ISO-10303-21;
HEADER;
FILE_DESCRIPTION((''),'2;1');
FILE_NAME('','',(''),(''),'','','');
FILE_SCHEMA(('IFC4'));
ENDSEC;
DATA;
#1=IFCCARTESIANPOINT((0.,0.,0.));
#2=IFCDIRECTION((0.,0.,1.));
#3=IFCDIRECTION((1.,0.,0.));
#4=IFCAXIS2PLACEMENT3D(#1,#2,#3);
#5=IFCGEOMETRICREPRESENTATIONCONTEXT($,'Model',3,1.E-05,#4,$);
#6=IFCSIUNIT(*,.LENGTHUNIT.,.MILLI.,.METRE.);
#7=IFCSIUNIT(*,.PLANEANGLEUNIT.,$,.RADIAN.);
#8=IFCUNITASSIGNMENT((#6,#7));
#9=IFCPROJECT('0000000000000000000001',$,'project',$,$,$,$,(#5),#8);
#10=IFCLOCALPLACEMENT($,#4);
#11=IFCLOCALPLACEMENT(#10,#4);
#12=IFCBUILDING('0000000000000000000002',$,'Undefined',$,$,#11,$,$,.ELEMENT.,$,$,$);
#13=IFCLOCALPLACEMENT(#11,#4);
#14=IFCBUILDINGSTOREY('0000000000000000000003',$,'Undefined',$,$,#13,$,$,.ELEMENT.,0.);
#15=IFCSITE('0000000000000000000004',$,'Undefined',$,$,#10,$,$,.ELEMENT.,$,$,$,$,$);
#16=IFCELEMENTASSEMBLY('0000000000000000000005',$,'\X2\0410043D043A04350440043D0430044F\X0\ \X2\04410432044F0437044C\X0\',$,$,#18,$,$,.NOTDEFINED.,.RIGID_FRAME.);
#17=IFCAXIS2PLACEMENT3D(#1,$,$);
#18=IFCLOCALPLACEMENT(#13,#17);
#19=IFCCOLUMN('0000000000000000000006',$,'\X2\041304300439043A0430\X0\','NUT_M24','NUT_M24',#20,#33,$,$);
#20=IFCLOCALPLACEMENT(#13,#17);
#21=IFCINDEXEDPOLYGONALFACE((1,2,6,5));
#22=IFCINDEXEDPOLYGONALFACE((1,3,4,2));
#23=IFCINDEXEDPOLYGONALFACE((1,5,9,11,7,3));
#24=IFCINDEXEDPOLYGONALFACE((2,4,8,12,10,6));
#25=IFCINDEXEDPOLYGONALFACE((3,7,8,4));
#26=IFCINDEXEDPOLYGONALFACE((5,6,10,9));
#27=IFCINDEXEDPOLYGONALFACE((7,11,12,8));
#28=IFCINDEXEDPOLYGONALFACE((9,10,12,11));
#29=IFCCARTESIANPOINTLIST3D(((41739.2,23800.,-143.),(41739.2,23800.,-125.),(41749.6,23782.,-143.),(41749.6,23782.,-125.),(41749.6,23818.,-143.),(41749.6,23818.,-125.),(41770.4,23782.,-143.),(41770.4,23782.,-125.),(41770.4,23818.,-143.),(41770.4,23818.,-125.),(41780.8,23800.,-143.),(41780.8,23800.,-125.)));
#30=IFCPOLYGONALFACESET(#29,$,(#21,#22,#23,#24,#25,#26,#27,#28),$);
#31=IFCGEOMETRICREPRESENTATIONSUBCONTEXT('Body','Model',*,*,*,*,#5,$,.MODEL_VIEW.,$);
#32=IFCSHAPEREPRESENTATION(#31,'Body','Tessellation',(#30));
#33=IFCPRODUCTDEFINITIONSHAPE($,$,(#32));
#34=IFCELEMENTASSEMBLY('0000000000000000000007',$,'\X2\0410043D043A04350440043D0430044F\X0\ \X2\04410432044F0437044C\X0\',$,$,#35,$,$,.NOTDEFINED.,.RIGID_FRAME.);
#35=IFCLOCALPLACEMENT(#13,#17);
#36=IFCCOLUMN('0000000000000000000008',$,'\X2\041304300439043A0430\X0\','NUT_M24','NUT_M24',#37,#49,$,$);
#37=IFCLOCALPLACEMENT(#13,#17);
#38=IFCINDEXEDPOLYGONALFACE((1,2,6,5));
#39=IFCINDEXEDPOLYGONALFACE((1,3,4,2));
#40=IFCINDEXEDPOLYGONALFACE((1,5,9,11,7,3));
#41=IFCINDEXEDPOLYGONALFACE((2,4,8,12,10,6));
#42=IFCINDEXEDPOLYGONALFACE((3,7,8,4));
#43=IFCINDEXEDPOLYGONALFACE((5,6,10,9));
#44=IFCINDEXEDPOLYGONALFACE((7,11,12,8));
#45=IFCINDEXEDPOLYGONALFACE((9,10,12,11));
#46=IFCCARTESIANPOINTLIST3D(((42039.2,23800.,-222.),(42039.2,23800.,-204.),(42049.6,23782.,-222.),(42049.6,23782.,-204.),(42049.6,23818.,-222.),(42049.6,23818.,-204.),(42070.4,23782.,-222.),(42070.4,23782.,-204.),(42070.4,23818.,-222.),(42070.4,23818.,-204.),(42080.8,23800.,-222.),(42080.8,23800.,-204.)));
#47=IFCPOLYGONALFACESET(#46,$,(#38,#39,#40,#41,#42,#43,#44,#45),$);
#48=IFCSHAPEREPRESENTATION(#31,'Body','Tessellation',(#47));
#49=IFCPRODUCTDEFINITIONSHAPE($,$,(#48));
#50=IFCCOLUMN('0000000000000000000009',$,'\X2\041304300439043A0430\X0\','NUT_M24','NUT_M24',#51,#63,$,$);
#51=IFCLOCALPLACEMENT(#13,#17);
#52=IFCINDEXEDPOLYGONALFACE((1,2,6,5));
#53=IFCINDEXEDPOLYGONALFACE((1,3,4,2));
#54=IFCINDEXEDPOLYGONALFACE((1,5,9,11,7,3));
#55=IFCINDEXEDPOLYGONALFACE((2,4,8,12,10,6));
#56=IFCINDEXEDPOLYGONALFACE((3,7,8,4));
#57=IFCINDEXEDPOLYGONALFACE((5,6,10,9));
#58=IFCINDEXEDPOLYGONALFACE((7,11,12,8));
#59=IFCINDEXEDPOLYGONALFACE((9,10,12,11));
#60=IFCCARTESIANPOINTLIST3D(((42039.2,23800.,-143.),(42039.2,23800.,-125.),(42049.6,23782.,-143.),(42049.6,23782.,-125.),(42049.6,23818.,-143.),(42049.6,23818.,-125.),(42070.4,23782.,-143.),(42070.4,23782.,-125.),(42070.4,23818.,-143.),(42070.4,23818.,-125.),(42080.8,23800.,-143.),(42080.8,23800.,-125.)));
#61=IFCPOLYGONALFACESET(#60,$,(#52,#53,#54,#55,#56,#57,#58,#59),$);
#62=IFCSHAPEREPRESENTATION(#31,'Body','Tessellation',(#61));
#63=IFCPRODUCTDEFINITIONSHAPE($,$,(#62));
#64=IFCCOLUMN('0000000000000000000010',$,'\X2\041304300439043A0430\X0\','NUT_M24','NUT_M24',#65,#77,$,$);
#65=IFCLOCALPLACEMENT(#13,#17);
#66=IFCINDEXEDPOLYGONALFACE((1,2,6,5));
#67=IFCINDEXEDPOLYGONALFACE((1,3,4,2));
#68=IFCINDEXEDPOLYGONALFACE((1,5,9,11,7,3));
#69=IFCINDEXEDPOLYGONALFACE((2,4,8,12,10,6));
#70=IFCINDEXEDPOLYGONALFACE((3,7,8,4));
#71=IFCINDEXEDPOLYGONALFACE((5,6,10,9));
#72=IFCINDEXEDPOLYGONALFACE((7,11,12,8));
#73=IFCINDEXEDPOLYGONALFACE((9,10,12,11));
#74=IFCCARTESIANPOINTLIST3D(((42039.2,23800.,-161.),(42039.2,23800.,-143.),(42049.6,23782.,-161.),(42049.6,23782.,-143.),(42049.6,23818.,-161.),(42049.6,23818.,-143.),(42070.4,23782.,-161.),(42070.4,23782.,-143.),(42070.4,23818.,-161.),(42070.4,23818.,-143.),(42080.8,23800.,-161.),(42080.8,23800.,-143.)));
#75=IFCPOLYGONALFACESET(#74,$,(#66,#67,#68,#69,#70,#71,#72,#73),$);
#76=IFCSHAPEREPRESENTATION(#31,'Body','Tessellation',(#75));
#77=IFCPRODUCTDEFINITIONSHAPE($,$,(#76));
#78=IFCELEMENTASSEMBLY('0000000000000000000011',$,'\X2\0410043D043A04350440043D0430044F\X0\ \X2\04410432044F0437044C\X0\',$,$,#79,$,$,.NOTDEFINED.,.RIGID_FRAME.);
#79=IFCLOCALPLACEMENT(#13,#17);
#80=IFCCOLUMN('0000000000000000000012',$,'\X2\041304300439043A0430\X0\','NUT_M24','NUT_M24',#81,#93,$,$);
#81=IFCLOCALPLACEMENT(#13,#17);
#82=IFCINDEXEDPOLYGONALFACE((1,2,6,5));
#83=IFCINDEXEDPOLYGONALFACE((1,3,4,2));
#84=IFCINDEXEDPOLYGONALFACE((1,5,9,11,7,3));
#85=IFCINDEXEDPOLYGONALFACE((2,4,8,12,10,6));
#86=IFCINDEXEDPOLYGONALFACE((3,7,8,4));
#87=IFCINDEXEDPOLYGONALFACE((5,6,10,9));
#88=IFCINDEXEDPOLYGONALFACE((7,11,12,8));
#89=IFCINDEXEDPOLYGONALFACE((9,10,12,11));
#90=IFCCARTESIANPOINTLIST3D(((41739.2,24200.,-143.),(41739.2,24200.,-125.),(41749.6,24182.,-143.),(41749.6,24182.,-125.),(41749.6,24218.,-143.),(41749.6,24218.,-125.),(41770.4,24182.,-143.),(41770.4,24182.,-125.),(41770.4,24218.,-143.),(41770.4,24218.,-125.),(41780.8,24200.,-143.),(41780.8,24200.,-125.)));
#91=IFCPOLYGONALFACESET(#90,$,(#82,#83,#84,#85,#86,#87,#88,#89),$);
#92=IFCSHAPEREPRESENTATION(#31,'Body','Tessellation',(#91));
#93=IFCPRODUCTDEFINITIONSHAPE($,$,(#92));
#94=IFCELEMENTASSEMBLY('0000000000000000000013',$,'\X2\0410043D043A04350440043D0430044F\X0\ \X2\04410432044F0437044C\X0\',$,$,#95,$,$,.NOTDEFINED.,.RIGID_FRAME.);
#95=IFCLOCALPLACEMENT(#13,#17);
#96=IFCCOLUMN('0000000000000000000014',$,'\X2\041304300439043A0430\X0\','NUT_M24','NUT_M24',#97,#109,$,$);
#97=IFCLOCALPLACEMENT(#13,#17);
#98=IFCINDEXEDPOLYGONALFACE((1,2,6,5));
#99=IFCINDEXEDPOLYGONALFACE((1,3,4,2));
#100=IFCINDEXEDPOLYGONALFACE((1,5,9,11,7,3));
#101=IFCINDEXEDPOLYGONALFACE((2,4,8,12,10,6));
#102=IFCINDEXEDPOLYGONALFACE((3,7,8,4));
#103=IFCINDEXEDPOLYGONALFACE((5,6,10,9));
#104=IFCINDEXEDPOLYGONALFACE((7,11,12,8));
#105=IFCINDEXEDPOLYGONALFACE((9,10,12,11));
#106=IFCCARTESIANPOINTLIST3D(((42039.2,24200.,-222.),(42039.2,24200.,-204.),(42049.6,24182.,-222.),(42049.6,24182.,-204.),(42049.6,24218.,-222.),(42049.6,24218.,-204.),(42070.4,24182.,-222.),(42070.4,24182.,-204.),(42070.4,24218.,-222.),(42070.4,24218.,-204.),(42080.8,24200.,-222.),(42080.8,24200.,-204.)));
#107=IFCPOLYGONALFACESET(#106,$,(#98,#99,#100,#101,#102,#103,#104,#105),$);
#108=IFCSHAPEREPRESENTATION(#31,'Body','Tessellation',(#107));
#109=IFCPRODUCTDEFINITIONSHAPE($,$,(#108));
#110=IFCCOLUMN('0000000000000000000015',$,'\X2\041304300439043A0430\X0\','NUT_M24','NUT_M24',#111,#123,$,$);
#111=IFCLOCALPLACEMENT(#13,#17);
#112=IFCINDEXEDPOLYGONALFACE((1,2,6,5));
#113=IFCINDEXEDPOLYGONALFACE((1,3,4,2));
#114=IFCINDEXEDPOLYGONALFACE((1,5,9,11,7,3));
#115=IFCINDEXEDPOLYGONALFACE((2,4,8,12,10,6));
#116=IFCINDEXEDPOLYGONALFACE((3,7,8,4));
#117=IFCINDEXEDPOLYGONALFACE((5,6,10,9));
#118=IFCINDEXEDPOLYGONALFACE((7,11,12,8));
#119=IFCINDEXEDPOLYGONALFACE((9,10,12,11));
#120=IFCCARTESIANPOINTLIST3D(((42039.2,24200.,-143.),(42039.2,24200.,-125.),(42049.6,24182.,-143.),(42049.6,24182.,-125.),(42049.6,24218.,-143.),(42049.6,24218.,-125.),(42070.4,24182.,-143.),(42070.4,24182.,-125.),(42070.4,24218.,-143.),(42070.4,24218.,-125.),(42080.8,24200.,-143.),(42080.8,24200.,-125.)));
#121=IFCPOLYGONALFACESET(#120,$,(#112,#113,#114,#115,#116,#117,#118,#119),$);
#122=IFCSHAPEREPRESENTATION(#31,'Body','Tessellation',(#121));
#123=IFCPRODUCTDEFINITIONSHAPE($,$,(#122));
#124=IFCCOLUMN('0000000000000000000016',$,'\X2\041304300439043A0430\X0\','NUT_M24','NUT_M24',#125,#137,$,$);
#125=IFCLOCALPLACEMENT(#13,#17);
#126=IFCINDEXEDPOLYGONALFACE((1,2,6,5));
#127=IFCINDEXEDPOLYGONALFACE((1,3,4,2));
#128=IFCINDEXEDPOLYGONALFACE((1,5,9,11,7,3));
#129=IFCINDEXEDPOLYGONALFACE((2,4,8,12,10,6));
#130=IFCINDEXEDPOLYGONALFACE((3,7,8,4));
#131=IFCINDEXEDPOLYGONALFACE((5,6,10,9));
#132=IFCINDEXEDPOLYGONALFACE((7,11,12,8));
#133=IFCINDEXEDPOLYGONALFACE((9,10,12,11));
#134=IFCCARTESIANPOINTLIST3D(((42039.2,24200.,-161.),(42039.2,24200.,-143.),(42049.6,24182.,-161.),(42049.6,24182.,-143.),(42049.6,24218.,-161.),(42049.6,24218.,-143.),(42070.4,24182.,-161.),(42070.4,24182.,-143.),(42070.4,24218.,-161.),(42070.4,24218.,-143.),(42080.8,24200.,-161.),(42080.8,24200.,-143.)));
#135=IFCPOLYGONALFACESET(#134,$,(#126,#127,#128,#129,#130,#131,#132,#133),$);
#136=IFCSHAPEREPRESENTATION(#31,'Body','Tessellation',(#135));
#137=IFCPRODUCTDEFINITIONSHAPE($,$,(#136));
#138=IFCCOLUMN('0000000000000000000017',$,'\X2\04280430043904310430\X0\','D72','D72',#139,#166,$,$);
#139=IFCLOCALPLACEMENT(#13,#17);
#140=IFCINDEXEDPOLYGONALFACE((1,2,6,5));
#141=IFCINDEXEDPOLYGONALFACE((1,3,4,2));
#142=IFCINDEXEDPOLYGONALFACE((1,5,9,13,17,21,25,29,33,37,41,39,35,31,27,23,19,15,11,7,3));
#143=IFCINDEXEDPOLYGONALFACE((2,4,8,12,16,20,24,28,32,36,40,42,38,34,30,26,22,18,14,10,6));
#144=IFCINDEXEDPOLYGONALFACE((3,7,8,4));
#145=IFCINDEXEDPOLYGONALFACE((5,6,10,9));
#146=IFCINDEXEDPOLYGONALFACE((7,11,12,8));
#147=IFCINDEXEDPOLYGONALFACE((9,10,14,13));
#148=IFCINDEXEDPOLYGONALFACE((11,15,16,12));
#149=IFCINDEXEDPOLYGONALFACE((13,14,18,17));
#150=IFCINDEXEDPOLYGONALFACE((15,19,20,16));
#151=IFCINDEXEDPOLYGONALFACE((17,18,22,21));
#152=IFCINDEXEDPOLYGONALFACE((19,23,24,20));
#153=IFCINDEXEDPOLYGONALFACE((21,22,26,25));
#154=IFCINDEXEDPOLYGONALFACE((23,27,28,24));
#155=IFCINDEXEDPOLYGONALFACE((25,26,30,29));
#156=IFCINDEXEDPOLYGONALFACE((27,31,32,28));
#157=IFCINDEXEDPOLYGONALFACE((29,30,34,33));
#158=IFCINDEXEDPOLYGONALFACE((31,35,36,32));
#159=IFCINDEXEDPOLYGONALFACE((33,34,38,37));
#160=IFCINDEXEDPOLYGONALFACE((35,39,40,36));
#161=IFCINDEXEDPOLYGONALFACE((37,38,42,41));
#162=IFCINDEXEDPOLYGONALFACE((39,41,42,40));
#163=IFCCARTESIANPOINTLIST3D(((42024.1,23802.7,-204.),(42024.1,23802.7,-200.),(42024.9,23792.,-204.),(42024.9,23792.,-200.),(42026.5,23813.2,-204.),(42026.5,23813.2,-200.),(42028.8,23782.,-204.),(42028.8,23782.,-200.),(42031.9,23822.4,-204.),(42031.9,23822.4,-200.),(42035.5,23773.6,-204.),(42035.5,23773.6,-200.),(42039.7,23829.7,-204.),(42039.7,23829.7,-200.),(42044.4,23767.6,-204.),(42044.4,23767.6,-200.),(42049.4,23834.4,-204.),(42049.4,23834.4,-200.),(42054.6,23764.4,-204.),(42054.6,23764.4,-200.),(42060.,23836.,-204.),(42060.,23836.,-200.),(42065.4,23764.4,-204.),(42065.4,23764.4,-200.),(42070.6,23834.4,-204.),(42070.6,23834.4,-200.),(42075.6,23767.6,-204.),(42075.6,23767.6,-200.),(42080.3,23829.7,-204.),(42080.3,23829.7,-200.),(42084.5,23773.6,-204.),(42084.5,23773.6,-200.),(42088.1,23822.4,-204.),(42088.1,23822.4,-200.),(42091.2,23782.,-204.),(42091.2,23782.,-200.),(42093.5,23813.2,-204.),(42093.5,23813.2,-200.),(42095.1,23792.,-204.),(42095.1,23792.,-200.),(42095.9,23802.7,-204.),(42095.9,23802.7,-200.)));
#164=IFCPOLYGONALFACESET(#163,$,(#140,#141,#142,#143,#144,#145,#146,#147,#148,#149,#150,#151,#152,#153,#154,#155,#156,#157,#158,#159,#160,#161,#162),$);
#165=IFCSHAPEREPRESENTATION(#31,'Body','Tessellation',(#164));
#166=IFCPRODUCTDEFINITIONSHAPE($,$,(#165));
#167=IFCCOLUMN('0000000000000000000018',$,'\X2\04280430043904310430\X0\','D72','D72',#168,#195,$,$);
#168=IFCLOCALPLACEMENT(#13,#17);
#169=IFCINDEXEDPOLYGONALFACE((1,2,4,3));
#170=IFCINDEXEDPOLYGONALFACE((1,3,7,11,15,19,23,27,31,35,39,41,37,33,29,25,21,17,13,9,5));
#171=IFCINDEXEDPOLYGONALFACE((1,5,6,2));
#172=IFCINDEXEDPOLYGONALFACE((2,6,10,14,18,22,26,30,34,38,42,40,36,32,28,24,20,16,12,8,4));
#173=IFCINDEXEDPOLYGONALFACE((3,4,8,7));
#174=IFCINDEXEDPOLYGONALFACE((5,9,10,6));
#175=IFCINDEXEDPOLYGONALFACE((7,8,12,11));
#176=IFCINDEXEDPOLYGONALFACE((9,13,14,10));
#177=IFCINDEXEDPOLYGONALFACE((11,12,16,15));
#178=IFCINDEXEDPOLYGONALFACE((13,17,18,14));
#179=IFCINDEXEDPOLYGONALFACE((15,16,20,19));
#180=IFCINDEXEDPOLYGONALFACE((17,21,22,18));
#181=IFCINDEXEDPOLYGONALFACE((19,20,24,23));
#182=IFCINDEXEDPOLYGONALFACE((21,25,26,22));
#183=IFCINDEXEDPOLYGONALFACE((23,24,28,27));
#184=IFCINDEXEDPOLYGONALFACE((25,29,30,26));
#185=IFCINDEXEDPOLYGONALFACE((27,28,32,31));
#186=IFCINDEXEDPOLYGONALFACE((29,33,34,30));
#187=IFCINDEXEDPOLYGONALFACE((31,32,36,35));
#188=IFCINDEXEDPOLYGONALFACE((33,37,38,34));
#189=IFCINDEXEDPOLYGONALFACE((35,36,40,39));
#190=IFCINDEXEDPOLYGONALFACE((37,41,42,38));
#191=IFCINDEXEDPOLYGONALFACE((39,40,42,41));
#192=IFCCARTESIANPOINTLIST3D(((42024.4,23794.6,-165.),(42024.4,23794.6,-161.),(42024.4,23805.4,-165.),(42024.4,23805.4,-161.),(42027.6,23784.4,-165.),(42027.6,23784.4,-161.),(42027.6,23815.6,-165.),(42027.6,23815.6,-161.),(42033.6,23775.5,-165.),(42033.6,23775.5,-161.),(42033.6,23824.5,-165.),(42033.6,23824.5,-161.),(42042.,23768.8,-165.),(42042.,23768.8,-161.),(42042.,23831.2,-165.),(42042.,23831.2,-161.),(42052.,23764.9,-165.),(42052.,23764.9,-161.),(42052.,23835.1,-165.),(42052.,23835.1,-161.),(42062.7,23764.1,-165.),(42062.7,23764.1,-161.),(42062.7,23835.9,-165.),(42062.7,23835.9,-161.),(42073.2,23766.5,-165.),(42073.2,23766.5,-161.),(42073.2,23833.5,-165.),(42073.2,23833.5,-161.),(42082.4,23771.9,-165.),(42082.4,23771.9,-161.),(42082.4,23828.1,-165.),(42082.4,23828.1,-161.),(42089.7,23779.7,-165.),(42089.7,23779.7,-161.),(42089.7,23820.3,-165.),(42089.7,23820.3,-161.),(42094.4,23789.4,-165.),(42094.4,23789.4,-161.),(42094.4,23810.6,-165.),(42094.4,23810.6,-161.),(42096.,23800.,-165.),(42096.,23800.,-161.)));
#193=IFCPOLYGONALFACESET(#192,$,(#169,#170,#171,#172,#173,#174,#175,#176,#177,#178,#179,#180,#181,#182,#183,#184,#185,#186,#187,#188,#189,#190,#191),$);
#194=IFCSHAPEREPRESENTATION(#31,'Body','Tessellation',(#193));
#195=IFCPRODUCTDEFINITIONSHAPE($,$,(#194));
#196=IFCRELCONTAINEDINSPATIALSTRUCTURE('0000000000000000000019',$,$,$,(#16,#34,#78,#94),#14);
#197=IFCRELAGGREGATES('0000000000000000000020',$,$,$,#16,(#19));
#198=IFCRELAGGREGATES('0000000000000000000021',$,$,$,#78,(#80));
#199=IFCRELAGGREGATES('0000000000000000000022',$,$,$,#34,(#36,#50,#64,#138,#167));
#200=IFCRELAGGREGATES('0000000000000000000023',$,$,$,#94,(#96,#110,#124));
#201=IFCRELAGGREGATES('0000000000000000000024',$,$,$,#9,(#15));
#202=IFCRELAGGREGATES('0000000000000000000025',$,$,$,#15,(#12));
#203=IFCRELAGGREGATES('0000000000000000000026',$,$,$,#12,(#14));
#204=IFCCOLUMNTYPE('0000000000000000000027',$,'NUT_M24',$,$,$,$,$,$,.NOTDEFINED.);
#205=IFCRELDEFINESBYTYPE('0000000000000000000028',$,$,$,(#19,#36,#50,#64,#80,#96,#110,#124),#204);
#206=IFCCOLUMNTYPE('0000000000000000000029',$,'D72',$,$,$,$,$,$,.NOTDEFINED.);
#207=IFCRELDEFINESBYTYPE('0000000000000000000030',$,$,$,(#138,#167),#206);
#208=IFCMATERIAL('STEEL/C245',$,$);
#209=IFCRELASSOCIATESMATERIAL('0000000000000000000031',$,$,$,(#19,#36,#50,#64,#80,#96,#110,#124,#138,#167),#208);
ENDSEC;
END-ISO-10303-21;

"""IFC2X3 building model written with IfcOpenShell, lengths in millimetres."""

from ifc_helpers import new_model, si_unit, frame, origin_with_axes, origin_2d_with_axis, place, context, subcontext, project, spatial, polyline, circle, outline, extrude, material, type_object, element, aggregate, save


model = new_model("IFC2X3")

# Units and contexts
model_context = context("Model", 3, precision=1e-05, world=origin_with_axes())
body_context = subcontext(model_context, "Body", "Model", "MODEL_VIEW")
ifc_project = project(units=[si_unit("LENGTHUNIT", "METRE", prefix="MILLI"), si_unit("PLANEANGLEUNIT", "RADIAN")], contexts=[model_context])

# Site, building, storey
site_placement = place(None, origin_with_axes())
site = spatial("IfcSite", under=ifc_project, at=site_placement, Name="Undefined", CompositionType="ELEMENT")
building_placement = place(site_placement, origin_with_axes())
building = spatial("IfcBuilding", under=site, at=building_placement, Name="Undefined", CompositionType="ELEMENT")
storey_placement = place(building_placement, origin_with_axes())
storey = spatial("IfcBuildingStorey", under=building, at=storey_placement, Name="Undefined", CompositionType="ELEMENT", Elevation=0.0)

# Element assembly, column
ifc_material_1 = material(Name="STEEL/C245")
assembly_1_placement = place(storey_placement, origin_with_axes())
assembly_1 = element("IfcElementAssembly", 1, at=assembly_1_placement, inside=storey, Name="Анкерная связь", AssemblyPlace="NOTDEFINED", PredefinedType="RIGID_FRAME")
column_type_1 = type_object("IfcColumnType", Name="NUT_M24", PredefinedType="NOTDEFINED")
column_1_placement = place(assembly_1_placement, frame((41760.0, 23800.0, -125.0), z_axis=(0.0, 0.0, -1.0), x_axis=(0.0, -1.0, 0.0)))
column_1 = element("IfcColumn", 2, at=column_1_placement, type_object=column_type_1, material=ifc_material_1, Name="Гайка", Description="NUT_M24", ObjectType="NUT_M24", context=body_context, shape_type="SweptSolid", body=[
    extrude(outline(polyline([(-10.4, 18.0), (10.4, 18.0), (20.8, 0.0), (10.4, -18.0), (-10.4, -18.0), (-20.8, 0.0), (-10.4, 18.0)])), frame((0.0, 0.0, 18.0), z_axis=(0.0, 0.0, -1.0), x_axis=(0.0, 1.0, 0.0)), (0.0, 0.0, 1.0), 18.0),
])

# Element assembly, columns
assembly_2_placement = place(storey_placement, origin_with_axes())
assembly_2 = element("IfcElementAssembly", 3, at=assembly_2_placement, inside=storey, Name="Анкерная связь", AssemblyPlace="NOTDEFINED", PredefinedType="RIGID_FRAME")
column_2_placement = place(assembly_2_placement, frame((42060.0, 23800.0, -204.0), z_axis=(0.0, 0.0, -1.0), x_axis=(0.0, 1.0, 0.0)))
column_2 = element("IfcColumn", 4, at=column_2_placement, type_object=column_type_1, material=ifc_material_1, Name="Гайка", Description="NUT_M24", ObjectType="NUT_M24", context=body_context, shape_type="SweptSolid", body=[
    extrude(outline(polyline([(-10.4, 18.0), (10.4, 18.0), (20.8, 0.0), (10.4, -18.0), (-10.4, -18.0), (-20.8, 0.0), (-10.4, 18.0)])), frame((0.0, 0.0, 18.0), z_axis=(0.0, 0.0, -1.0), x_axis=(0.0, 1.0, 0.0)), (0.0, 0.0, 1.0), 18.0),
])
column_3_placement = place(assembly_2_placement, frame((42060.0, 23800.0, -125.0), z_axis=(0.0, 0.0, -1.0), x_axis=(0.0, 1.0, 0.0)))
column_3 = element("IfcColumn", 5, at=column_3_placement, type_object=column_type_1, material=ifc_material_1, Name="Гайка", Description="NUT_M24", ObjectType="NUT_M24", context=body_context, shape_type="SweptSolid", body=[
    extrude(outline(polyline([(-10.4, 18.0), (10.4, 18.0), (20.8, 0.0), (10.4, -18.0), (-10.4, -18.0), (-20.8, 0.0), (-10.4, 18.0)])), frame((0.0, 0.0, 18.0), z_axis=(0.0, 0.0, -1.0), x_axis=(0.0, 1.0, 0.0)), (0.0, 0.0, 1.0), 18.0),
])
column_4_placement = place(assembly_2_placement, frame((42060.0, 23800.0, -143.0), z_axis=(0.0, 0.0, -1.0), x_axis=(0.0, 1.0, 0.0)))
column_4 = element("IfcColumn", 6, at=column_4_placement, type_object=column_type_1, material=ifc_material_1, Name="Гайка", Description="NUT_M24", ObjectType="NUT_M24", context=body_context, shape_type="SweptSolid", body=[
    extrude(outline(polyline([(-10.4, 18.0), (10.4, 18.0), (20.8, 0.0), (10.4, -18.0), (-10.4, -18.0), (-20.8, 0.0), (-10.4, 18.0)])), frame((0.0, 0.0, 18.0), z_axis=(0.0, 0.0, -1.0), x_axis=(0.0, 1.0, 0.0)), (0.0, 0.0, 1.0), 18.0),
])

# Element assembly, column
assembly_3_placement = place(storey_placement, origin_with_axes())
assembly_3 = element("IfcElementAssembly", 7, at=assembly_3_placement, inside=storey, Name="Анкерная связь", AssemblyPlace="NOTDEFINED", PredefinedType="RIGID_FRAME")
column_5_placement = place(assembly_3_placement, frame((41760.0, 24200.0, -125.0), z_axis=(0.0, 0.0, -1.0), x_axis=(0.0, -1.0, 0.0)))
column_5 = element("IfcColumn", 8, at=column_5_placement, type_object=column_type_1, material=ifc_material_1, Name="Гайка", Description="NUT_M24", ObjectType="NUT_M24", context=body_context, shape_type="SweptSolid", body=[
    extrude(outline(polyline([(-10.4, 18.0), (10.4, 18.0), (20.8, 0.0), (10.4, -18.0), (-10.4, -18.0), (-20.8, 0.0), (-10.4, 18.0)])), frame((0.0, 0.0, 18.0), z_axis=(0.0, 0.0, -1.0), x_axis=(0.0, 1.0, 0.0)), (0.0, 0.0, 1.0), 18.0),
])

# Element assembly, columns
assembly_4_placement = place(storey_placement, origin_with_axes())
assembly_4 = element("IfcElementAssembly", 9, at=assembly_4_placement, inside=storey, Name="Анкерная связь", AssemblyPlace="NOTDEFINED", PredefinedType="RIGID_FRAME")
column_6_placement = place(assembly_4_placement, frame((42060.0, 24200.0, -204.0), z_axis=(0.0, 0.0, -1.0), x_axis=(0.0, 1.0, 0.0)))
column_6 = element("IfcColumn", 10, at=column_6_placement, type_object=column_type_1, material=ifc_material_1, Name="Гайка", Description="NUT_M24", ObjectType="NUT_M24", context=body_context, shape_type="SweptSolid", body=[
    extrude(outline(polyline([(-10.4, 18.0), (10.4, 18.0), (20.8, 0.0), (10.4, -18.0), (-10.4, -18.0), (-20.8, 0.0), (-10.4, 18.0)])), frame((0.0, 0.0, 18.0), z_axis=(0.0, 0.0, -1.0), x_axis=(0.0, 1.0, 0.0)), (0.0, 0.0, 1.0), 18.0),
])
column_7_placement = place(assembly_4_placement, frame((42060.0, 24200.0, -125.0), z_axis=(0.0, 0.0, -1.0), x_axis=(0.0, 1.0, 0.0)))
column_7 = element("IfcColumn", 11, at=column_7_placement, type_object=column_type_1, material=ifc_material_1, Name="Гайка", Description="NUT_M24", ObjectType="NUT_M24", context=body_context, shape_type="SweptSolid", body=[
    extrude(outline(polyline([(-10.4, 18.0), (10.4, 18.0), (20.8, 0.0), (10.4, -18.0), (-10.4, -18.0), (-20.8, 0.0), (-10.4, 18.0)])), frame((0.0, 0.0, 18.0), z_axis=(0.0, 0.0, -1.0), x_axis=(0.0, 1.0, 0.0)), (0.0, 0.0, 1.0), 18.0),
])
column_8_placement = place(assembly_4_placement, frame((42060.0, 24200.0, -143.0), z_axis=(0.0, 0.0, -1.0), x_axis=(0.0, 1.0, 0.0)))
column_8 = element("IfcColumn", 12, at=column_8_placement, type_object=column_type_1, material=ifc_material_1, Name="Гайка", Description="NUT_M24", ObjectType="NUT_M24", context=body_context, shape_type="SweptSolid", body=[
    extrude(outline(polyline([(-10.4, 18.0), (10.4, 18.0), (20.8, 0.0), (10.4, -18.0), (-10.4, -18.0), (-20.8, 0.0), (-10.4, 18.0)])), frame((0.0, 0.0, 18.0), z_axis=(0.0, 0.0, -1.0), x_axis=(0.0, 1.0, 0.0)), (0.0, 0.0, 1.0), 18.0),
])

# Columns
column_type_2 = type_object("IfcColumnType", Name="D72", PredefinedType="NOTDEFINED")
column_9_placement = place(assembly_2_placement, frame((42060.0, 23800.0, -200.0), z_axis=(0.0, 0.0, -1.0), x_axis=(-1.0, 0.0, 0.0)))
column_9 = element("IfcColumn", 13, at=column_9_placement, type_object=column_type_2, material=ifc_material_1, Name="Шайба", Description="D72", ObjectType="D72", context=body_context, shape_type="SweptSolid", body=[
    extrude(circle(Radius=36.0, at=origin_2d_with_axis()), frame((0.0, 0.0, 4.0), z_axis=(0.0, 0.0, -1.0), x_axis=(0.0, 1.0, 0.0)), (0.0, 0.0, 1.0), 4.0),
])
column_10_placement = place(assembly_2_placement, frame((42060.0, 23800.0, -161.0), z_axis=(0.0, 0.0, -1.0), x_axis=(0.0, 1.0, 0.0)))
column_10 = element("IfcColumn", 14, at=column_10_placement, type_object=column_type_2, material=ifc_material_1, Name="Шайба", Description="D72", ObjectType="D72", context=body_context, shape_type="SweptSolid", body=[
    extrude(circle(Radius=36.0, at=origin_2d_with_axis()), frame((0.0, 0.0, 4.0), z_axis=(0.0, 0.0, -1.0), x_axis=(0.0, 1.0, 0.0)), (0.0, 0.0, 1.0), 4.0),
])

aggregate(assembly_1, [column_1])
aggregate(assembly_3, [column_5])

aggregate(assembly_2, [column_2, column_3, column_4, column_9, column_10])
aggregate(assembly_4, [column_6, column_7, column_8])

save(model, "model.ifc")
